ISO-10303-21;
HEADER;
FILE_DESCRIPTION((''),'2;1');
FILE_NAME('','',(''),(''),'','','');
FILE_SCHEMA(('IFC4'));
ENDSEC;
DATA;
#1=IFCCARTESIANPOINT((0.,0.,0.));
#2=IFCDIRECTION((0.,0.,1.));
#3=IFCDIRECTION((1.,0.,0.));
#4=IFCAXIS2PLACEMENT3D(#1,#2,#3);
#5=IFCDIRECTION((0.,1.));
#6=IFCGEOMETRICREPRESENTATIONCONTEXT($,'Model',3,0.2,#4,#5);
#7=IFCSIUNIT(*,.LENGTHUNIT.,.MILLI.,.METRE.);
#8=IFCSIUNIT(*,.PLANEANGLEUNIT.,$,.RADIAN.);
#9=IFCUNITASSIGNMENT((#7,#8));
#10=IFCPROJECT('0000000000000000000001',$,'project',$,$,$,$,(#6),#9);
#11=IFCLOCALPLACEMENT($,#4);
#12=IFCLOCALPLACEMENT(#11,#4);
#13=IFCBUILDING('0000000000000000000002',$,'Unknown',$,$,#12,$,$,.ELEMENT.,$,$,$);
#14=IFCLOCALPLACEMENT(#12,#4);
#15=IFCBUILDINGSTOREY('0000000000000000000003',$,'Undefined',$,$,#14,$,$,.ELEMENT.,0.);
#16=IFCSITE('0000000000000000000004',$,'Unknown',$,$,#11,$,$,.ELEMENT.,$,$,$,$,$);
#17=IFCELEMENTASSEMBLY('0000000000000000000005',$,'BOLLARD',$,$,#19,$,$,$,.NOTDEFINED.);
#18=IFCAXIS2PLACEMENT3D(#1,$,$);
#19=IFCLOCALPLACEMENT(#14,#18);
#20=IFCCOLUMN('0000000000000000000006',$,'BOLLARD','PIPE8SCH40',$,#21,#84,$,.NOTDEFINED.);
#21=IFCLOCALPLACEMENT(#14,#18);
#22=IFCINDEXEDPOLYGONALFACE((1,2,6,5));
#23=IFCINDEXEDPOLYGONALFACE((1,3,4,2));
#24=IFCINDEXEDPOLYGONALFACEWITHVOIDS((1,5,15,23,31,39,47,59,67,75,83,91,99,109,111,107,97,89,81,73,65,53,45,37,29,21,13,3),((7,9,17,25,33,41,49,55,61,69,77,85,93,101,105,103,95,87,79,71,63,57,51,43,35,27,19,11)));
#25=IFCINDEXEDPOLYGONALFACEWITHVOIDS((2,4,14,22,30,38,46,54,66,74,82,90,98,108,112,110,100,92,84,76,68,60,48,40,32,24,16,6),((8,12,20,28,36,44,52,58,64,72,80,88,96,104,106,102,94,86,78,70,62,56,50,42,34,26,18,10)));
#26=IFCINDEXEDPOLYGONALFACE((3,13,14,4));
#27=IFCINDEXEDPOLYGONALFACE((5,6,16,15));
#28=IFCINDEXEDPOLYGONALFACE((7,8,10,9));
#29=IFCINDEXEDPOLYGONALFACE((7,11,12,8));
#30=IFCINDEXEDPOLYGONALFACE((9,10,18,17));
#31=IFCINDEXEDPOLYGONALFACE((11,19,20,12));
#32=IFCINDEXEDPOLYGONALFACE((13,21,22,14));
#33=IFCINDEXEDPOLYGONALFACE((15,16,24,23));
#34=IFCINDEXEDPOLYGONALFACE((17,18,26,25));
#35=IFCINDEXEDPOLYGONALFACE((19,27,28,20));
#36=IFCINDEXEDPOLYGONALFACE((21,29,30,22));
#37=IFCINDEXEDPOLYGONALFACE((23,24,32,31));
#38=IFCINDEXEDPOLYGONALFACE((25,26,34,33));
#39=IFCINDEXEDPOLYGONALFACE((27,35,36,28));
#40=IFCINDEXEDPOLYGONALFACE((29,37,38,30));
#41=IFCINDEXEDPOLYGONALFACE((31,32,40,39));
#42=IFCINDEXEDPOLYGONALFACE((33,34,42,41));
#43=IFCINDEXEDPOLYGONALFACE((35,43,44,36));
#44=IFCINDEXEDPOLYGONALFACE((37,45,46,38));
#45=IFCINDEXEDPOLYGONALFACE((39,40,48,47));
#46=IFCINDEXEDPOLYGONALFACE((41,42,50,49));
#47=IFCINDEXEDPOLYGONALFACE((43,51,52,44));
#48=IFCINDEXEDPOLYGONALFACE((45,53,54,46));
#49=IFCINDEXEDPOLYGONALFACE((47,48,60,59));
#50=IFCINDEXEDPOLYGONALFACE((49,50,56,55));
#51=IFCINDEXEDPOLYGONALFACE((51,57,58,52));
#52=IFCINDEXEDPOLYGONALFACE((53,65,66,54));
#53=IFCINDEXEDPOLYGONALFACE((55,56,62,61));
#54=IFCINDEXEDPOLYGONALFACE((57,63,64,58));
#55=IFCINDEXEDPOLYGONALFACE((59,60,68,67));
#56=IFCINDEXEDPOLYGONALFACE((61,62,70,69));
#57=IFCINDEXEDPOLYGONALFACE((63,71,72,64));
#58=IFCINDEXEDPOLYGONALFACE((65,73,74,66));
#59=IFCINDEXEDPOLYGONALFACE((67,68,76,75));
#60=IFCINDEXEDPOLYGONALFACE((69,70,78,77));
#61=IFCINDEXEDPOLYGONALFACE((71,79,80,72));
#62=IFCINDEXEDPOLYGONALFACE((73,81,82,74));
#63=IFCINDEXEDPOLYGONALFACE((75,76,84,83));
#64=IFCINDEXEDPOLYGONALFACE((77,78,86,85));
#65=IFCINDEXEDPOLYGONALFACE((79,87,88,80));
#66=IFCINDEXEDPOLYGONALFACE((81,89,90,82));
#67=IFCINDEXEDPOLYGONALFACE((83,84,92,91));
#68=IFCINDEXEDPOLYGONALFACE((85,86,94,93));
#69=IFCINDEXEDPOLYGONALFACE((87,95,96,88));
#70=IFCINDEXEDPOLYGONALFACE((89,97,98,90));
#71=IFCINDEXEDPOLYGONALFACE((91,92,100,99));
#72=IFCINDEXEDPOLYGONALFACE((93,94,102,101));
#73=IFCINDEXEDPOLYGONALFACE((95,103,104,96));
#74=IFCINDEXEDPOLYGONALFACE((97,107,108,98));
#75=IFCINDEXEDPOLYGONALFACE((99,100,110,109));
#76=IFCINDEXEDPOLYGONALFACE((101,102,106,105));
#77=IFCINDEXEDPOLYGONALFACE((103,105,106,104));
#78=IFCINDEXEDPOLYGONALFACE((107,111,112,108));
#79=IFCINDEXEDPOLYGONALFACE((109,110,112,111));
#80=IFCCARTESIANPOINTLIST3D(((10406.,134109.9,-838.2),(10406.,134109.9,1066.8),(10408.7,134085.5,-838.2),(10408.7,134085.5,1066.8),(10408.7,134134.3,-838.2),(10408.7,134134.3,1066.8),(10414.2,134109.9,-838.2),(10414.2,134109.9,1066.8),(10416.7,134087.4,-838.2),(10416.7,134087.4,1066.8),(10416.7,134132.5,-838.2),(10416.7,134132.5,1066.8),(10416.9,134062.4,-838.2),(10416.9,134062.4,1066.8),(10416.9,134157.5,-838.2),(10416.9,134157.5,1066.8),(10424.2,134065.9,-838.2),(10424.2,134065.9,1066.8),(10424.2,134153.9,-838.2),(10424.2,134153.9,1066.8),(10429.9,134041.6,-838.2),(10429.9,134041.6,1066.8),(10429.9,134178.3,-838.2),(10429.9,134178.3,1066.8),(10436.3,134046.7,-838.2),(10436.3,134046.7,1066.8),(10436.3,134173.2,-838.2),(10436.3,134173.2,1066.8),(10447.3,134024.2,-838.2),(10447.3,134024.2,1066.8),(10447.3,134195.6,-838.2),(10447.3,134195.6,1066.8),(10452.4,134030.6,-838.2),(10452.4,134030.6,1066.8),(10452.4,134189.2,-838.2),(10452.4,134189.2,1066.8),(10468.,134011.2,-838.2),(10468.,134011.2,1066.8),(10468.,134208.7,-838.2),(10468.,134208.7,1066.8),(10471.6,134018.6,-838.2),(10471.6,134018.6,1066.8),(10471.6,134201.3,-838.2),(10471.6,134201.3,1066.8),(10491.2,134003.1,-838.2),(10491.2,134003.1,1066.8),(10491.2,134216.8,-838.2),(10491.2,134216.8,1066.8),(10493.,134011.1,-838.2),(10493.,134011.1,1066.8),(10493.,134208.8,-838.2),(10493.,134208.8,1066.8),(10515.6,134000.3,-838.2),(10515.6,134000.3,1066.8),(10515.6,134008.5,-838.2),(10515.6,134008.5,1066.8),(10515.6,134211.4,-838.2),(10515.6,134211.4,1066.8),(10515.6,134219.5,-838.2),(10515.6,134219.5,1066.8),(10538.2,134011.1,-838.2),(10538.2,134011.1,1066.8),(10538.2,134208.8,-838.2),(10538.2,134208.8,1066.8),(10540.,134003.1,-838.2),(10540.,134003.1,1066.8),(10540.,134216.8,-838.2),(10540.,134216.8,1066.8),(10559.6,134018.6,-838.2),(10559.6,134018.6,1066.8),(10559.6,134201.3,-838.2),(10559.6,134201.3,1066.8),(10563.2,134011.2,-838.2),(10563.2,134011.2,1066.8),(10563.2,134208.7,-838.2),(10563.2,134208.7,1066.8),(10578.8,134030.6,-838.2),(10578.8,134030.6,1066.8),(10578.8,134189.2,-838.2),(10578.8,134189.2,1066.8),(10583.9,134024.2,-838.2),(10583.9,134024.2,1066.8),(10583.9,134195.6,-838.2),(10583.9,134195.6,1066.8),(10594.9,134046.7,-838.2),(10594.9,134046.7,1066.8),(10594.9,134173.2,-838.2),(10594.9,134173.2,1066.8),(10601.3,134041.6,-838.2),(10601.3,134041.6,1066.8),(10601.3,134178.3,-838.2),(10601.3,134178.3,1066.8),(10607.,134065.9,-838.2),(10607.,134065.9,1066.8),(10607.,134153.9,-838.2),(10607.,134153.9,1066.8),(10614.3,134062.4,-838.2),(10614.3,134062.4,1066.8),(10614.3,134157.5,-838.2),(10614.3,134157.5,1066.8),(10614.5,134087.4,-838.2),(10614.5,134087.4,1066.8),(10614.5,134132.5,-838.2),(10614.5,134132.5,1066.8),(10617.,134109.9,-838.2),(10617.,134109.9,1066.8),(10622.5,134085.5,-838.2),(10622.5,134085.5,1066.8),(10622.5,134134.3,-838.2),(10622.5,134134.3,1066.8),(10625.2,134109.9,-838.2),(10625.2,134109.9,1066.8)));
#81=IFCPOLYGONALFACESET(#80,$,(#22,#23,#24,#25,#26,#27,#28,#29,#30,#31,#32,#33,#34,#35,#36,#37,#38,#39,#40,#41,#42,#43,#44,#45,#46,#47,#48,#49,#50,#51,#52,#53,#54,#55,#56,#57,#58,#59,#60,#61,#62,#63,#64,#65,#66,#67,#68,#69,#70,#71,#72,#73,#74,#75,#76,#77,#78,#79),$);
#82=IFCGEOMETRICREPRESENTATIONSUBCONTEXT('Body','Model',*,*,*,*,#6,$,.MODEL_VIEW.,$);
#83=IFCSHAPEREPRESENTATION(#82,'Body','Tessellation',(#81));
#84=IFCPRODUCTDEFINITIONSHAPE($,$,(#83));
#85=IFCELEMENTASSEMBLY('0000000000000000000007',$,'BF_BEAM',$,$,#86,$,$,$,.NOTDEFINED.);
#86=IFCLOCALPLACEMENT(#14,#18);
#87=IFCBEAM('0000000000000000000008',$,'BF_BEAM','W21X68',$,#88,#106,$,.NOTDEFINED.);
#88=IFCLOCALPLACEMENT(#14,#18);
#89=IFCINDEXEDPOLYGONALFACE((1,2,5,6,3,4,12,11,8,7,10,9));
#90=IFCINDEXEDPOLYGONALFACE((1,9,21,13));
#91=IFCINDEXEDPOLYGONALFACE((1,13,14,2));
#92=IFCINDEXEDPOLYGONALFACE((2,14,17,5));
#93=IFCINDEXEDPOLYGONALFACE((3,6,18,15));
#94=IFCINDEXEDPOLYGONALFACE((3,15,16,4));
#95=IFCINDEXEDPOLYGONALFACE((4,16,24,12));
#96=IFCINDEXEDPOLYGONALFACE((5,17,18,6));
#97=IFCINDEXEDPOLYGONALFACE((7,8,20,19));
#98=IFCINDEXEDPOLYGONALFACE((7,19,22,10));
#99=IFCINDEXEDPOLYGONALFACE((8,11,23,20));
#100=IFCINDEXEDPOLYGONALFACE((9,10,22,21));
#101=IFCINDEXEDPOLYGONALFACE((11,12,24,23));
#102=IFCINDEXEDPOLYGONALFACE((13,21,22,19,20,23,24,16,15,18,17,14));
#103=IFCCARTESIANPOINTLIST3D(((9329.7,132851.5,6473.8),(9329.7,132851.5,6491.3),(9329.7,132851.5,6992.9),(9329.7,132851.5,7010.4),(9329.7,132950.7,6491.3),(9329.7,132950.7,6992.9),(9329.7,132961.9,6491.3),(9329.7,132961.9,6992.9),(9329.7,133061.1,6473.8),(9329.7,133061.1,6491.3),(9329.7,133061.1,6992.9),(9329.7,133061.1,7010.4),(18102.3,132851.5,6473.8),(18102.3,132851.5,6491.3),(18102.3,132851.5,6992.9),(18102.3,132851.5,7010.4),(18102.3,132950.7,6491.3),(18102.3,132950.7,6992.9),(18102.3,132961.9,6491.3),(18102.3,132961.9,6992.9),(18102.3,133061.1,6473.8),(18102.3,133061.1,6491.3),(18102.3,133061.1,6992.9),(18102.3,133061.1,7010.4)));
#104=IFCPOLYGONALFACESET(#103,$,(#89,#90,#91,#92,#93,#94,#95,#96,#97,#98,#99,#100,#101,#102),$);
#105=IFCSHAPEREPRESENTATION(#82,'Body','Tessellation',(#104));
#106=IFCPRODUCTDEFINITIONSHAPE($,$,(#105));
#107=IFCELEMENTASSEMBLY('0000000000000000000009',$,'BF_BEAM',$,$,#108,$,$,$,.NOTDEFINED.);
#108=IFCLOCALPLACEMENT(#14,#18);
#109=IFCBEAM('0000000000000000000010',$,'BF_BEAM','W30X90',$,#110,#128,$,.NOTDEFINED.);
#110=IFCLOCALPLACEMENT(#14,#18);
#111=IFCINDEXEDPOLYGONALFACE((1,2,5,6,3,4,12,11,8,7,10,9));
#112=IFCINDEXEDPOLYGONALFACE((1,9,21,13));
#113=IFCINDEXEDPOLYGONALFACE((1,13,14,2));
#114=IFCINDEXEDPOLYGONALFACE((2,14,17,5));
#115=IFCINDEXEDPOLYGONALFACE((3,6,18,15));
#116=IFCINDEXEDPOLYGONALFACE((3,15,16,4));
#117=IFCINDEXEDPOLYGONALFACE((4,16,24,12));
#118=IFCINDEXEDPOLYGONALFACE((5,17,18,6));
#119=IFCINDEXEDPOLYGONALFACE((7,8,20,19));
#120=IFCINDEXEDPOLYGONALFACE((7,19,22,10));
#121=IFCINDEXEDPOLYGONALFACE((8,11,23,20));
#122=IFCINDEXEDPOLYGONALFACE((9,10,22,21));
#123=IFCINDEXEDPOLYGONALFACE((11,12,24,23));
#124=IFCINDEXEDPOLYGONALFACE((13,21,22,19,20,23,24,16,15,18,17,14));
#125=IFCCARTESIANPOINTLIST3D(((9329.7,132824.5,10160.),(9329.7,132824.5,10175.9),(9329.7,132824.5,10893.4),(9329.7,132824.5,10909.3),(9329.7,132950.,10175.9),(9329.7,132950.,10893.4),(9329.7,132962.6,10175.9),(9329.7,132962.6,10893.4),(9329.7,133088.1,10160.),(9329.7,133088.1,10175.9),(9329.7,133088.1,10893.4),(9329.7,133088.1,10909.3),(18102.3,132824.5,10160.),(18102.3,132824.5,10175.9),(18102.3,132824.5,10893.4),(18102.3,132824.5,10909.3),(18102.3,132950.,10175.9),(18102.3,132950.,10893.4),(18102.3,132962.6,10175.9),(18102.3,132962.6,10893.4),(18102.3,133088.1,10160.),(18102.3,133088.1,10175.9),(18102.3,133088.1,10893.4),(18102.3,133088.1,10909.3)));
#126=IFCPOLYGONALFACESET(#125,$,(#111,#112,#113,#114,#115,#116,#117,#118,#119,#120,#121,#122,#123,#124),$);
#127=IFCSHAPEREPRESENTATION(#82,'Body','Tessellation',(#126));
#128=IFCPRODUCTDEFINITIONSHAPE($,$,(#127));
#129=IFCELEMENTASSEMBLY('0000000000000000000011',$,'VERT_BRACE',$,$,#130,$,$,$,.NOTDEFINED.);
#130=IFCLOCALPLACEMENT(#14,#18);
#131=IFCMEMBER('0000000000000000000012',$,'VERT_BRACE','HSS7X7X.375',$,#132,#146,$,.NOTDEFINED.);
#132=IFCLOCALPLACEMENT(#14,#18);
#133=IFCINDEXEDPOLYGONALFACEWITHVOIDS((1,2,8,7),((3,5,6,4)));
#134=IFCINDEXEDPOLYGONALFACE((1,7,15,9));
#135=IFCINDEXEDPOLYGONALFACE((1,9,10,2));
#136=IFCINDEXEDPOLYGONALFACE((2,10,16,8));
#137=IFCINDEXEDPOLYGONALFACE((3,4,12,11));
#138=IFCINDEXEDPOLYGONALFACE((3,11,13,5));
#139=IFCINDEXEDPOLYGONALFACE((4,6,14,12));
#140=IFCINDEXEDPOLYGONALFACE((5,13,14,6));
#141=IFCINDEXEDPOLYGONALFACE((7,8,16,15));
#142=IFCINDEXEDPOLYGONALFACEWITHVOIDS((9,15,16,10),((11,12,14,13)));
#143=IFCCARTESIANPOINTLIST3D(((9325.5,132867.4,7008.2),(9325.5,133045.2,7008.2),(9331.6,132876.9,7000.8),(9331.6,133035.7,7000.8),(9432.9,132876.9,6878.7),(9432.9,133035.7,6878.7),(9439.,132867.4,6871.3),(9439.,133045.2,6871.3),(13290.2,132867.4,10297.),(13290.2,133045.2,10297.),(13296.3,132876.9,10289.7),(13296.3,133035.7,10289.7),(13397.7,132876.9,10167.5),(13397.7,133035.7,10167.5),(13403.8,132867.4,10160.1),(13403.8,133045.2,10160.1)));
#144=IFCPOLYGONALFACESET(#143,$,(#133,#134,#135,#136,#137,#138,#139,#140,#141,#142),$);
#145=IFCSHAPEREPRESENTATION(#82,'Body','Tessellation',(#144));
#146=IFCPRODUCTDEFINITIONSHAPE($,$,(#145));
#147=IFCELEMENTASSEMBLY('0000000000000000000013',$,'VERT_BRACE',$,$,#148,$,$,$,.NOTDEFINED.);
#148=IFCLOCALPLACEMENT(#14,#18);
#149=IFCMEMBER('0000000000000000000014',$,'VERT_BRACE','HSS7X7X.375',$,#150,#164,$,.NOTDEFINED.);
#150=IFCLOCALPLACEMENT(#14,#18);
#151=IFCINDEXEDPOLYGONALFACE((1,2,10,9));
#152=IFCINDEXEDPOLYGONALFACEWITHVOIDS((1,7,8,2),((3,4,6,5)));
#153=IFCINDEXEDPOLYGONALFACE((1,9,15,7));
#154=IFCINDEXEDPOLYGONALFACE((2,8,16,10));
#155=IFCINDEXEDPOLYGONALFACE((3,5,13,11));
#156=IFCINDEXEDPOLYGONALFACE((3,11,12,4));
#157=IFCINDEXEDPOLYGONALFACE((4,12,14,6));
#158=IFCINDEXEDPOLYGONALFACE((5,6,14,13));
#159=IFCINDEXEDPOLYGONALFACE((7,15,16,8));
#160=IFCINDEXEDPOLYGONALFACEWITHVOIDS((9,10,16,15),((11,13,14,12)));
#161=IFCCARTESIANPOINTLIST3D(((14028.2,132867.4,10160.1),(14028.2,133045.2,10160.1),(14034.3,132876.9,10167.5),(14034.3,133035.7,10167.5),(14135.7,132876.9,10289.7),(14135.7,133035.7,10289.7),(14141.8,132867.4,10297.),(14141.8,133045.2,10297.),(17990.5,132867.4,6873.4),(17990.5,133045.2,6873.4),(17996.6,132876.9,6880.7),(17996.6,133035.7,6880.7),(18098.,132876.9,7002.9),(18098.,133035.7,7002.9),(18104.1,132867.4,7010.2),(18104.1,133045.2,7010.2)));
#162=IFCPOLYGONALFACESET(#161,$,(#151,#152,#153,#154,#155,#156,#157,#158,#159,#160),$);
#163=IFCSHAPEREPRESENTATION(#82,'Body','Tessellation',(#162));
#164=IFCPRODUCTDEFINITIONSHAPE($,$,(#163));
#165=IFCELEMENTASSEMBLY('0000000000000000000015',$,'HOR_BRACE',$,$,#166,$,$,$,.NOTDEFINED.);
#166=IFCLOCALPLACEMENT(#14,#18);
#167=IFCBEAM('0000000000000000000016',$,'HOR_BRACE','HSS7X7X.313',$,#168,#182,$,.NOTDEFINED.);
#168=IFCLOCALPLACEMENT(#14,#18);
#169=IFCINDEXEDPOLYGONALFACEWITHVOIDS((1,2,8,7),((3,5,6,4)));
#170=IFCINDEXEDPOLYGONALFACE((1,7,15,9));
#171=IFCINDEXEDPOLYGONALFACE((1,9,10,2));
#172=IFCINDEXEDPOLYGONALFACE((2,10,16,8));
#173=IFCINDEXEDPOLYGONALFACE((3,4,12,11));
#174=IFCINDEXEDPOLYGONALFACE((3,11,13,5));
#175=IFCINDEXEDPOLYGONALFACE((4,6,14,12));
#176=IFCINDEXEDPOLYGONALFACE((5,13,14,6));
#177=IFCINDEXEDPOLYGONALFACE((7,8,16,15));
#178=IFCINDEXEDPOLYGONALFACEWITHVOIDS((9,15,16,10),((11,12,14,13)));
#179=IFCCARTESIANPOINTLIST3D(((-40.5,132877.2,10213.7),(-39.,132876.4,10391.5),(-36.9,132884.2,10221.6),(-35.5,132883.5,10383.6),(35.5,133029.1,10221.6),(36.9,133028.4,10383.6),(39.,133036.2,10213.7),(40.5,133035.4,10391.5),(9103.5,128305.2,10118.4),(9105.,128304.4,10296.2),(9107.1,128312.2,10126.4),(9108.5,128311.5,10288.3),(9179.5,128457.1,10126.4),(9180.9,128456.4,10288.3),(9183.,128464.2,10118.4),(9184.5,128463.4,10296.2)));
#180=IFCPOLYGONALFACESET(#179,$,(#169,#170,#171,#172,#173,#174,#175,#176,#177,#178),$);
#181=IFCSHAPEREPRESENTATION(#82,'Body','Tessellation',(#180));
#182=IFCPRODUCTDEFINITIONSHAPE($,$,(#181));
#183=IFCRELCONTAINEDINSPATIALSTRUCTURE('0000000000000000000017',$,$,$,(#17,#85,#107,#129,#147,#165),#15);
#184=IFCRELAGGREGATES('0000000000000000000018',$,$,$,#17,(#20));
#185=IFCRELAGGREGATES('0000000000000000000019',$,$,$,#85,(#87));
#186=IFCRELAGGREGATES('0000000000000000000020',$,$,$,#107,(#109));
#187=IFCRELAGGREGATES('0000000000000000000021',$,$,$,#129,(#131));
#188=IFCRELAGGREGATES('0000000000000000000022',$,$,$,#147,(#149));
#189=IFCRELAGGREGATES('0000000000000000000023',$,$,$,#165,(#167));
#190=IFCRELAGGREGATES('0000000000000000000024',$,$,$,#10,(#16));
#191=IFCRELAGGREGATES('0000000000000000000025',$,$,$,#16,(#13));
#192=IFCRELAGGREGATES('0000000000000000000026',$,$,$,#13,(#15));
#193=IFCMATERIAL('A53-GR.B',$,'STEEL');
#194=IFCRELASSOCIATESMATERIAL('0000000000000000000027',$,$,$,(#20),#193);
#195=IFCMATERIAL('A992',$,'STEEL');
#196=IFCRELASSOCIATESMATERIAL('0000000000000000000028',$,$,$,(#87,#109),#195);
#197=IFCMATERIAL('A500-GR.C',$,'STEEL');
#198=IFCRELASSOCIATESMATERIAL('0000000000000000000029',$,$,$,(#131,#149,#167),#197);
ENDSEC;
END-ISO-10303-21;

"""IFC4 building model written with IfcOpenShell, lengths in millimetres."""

from ifc_helpers import new_model, si_unit, direction, frame, origin_with_axes, place, context, subcontext, project, spatial, line, indexed_curve, outline, extrude, material, element, aggregate, save


model = new_model("IFC4")

# Units and contexts
model_context = context("Model", 3, precision=0.2, world=origin_with_axes(), true_north=direction((0.0, 1.0)))
body_context = subcontext(model_context, "Body", "Model", "MODEL_VIEW")
ifc_project = project(units=[si_unit("LENGTHUNIT", "METRE", prefix="MILLI"), si_unit("PLANEANGLEUNIT", "RADIAN")], contexts=[model_context])

# Site, building, storey
site_placement = place(None, origin_with_axes())
site = spatial("IfcSite", under=ifc_project, at=site_placement, Name="Unknown", CompositionType="ELEMENT")
building_placement = place(site_placement, origin_with_axes())
building = spatial("IfcBuilding", under=site, at=building_placement, Name="Unknown", CompositionType="ELEMENT")
storey_placement = place(building_placement, origin_with_axes())
storey = spatial("IfcBuildingStorey", under=building, at=storey_placement, Name="Undefined", CompositionType="ELEMENT", Elevation=0.0)

# Element assembly, column
ifc_material_1 = material(Name="A992", Category="STEEL")
ifc_material_2 = material(Name="A500-GR.C", Category="STEEL")
ifc_material_3 = material(Name="A53-GR.B", Category="STEEL")
assembly_1_placement = place(storey_placement, frame((10515.6, 134109.9, -838.2), z_axis=(-1.0, 0.0, 0.0), x_axis=(0.0, 0.0, 1.0)))
assembly_1 = element("IfcElementAssembly", 1, at=assembly_1_placement, inside=storey, Name="BOLLARD", PredefinedType="NOTDEFINED")
column_1_placement = place(assembly_1_placement, origin_with_axes())
column_1 = element("IfcColumn", 2, at=column_1_placement, material=ifc_material_3, Name="BOLLARD", Description="PIPE8SCH40", PredefinedType="NOTDEFINED", context=body_context, shape_type="SolidModel", body=[
    extrude(outline(indexed_curve([(109.6, 0.0), (106.9, 24.4), (98.7, 47.6), (85.7, 68.3), (68.3, 85.7), (47.6, 98.7), (24.4, 106.9), (0.0, 109.6), (-24.4, 106.9), (-47.6, 98.7), (-68.3, 85.7), (-85.7, 68.3), (-98.7, 47.6), (-106.9, 24.4), (-109.6, 0.0), (-106.9, -24.4), (-98.7, -47.6), (-85.7, -68.3), (-68.3, -85.7), (-47.6, -98.7), (-24.4, -106.9), (0.0, -109.6), (24.4, -106.9), (47.6, -98.7), (68.3, -85.7), (85.7, -68.3), (98.7, -47.6), (106.9, -24.4)], segments=[line(1, 2, 3, 4, 5, 6, 7, 8, 9, 10, 11, 12, 13, 14, 15, 16, 17, 18, 19, 20, 21, 22, 23, 24, 25, 26, 27, 28, 1)]), holes=[indexed_curve([(101.4, 0.0), (98.9, -22.6), (91.4, -44.0), (79.3, -63.2), (63.2, -79.3), (44.0, -91.4), (22.6, -98.9), (0.0, -101.4), (-22.6, -98.9), (-44.0, -91.4), (-63.2, -79.3), (-79.3, -63.2), (-91.4, -44.0), (-98.9, -22.6), (-101.4, 0.0), (-98.9, 22.6), (-91.4, 44.0), (-79.3, 63.2), (-63.2, 79.3), (-44.0, 91.4), (-22.6, 98.9), (0.0, 101.4), (22.6, 98.9), (44.0, 91.4), (63.2, 79.3), (79.3, 63.2), (91.4, 44.0), (98.9, 22.6)], segments=[line(1, 2, 3, 4, 5, 6, 7, 8, 9, 10, 11, 12, 13, 14, 15, 16, 17, 18, 19, 20, 21, 22, 23, 24, 25, 26, 27, 28, 1)])]), frame((0.0, 0.0, 0.0), z_axis=(-1.0, 0.0, 0.0), x_axis=(0.0, 0.0, 1.0)), (0.0, 0.0, -1.0), 1905.0),
])
aggregate(assembly_1, [column_1])

# Element assemblies, beams
assembly_2_placement = place(storey_placement, frame((9329.7, 132956.3, 6742.1), z_axis=(0.0, -1.0, 0.0), x_axis=(1.0, 0.0, 0.0)))
assembly_2 = element("IfcElementAssembly", 3, at=assembly_2_placement, inside=storey, Name="BF_BEAM", PredefinedType="NOTDEFINED")
beam_1_placement = place(assembly_2_placement, origin_with_axes())
beam_1 = element("IfcBeam", 4, at=beam_1_placement, material=ifc_material_1, Name="BF_BEAM", Description="W21X68", PredefinedType="NOTDEFINED", context=body_context, shape_type="SolidModel", body=[
    extrude(outline(indexed_curve([(-104.8, -268.3), (104.8, -268.3), (104.8, -250.8), (5.6, -250.8), (5.6, 250.8), (104.8, 250.8), (104.8, 268.3), (-104.8, 268.3), (-104.8, 250.8), (-5.6, 250.8), (-5.6, -250.8), (-104.8, -250.8)], segments=[line(1, 2, 3, 4, 5, 6, 7, 8, 9, 10, 11, 12, 1)])), frame((0.0, 0.0, 0.0), z_axis=(-1.0, 0.0, 0.0), x_axis=(0.0, 0.0, 1.0)), (0.0, 0.0, -1.0), 8772.5),
])
aggregate(assembly_2, [beam_1])
assembly_3_placement = place(storey_placement, frame((9329.7, 132956.3, 10534.6), z_axis=(0.0, -1.0, 0.0), x_axis=(1.0, 0.0, 0.0)))
assembly_3 = element("IfcElementAssembly", 5, at=assembly_3_placement, inside=storey, Name="BF_BEAM", PredefinedType="NOTDEFINED")
beam_2_placement = place(assembly_3_placement, origin_with_axes())
beam_2 = element("IfcBeam", 6, at=beam_2_placement, material=ifc_material_1, Name="BF_BEAM", Description="W30X90", PredefinedType="NOTDEFINED", context=body_context, shape_type="SolidModel", body=[
    extrude(outline(indexed_curve([(-131.8, -374.6), (131.8, -374.6), (131.8, -358.8), (6.3, -358.8), (6.3, 358.8), (131.8, 358.8), (131.8, 374.6), (-131.8, 374.6), (-131.8, 358.8), (-6.3, 358.8), (-6.3, -358.8), (-131.8, -358.8)], segments=[line(1, 2, 3, 4, 5, 6, 7, 8, 9, 10, 11, 12, 1)])), frame((0.0, 0.0, 0.0), z_axis=(-1.0, 0.0, 0.0), x_axis=(0.0, 0.0, 1.0)), (0.0, 0.0, -1.0), 8772.5),
])
aggregate(assembly_3, [beam_2])

# Element assemblies, members
assembly_4_placement = place(storey_placement, frame((9382.3, 132956.3, 6939.8), z_axis=(0.0, -1.0, 0.0), x_axis=(0.769665, 0.0, 0.638448)))
assembly_4 = element("IfcElementAssembly", 7, at=assembly_4_placement, inside=storey, Name="VERT_BRACE", PredefinedType="NOTDEFINED")
member_1_placement = place(assembly_4_placement, origin_with_axes())
member_1 = element("IfcMember", 8, at=member_1_placement, material=ifc_material_2, Name="VERT_BRACE", Description="HSS7X7X.375", PredefinedType="NOTDEFINED", context=body_context, shape_type="SolidModel", body=[
    extrude(outline(indexed_curve([(-88.9, -88.9), (88.9, -88.9), (88.9, 88.9), (-88.9, 88.9)], segments=[line(1, 2, 3, 4, 1)]), holes=[indexed_curve([(-79.4, -79.4), (-79.4, 79.4), (79.4, 79.4), (79.4, -79.4)], segments=[line(1, 2, 3, 4, 1)])]), frame((0.0, 0.0, 0.0), z_axis=(-1.0, 0.0, 0.0), x_axis=(0.0, 0.0, 1.0)), (0.0, 0.0, -1.0), 5151.3),
])
aggregate(assembly_4, [member_1])
assembly_5_placement = place(storey_placement, frame((18047.3, 132956.3, 6941.8), z_axis=(0.0, 1.0, 0.0), x_axis=(-0.769665, 0.0, 0.638448)))
assembly_5 = element("IfcElementAssembly", 9, at=assembly_5_placement, inside=storey, Name="VERT_BRACE", PredefinedType="NOTDEFINED")
member_2_placement = place(assembly_5_placement, origin_with_axes())
member_2 = element("IfcMember", 10, at=member_2_placement, material=ifc_material_2, Name="VERT_BRACE", Description="HSS7X7X.375", PredefinedType="NOTDEFINED", context=body_context, shape_type="SolidModel", body=[
    extrude(outline(indexed_curve([(-88.9, -88.9), (88.9, -88.9), (88.9, 88.9), (-88.9, 88.9)], segments=[line(1, 2, 3, 4, 1)]), holes=[indexed_curve([(-79.4, -79.4), (-79.4, 79.4), (79.4, 79.4), (79.4, -79.4)], segments=[line(1, 2, 3, 4, 1)])]), frame((0.0, 0.0, 0.0), z_axis=(-1.0, 0.0, 0.0), x_axis=(0.0, 0.0, 1.0)), (0.0, 0.0, -1.0), 5148.1),
])
aggregate(assembly_5, [member_2])

# Element assembly, beam
assembly_6_placement = place(storey_placement, frame((9144.0, 128384.3, 10207.3), z_axis=(0.447214, 0.894427, 0.0), x_axis=(-0.894388, 0.447194, 0.009317)))
assembly_6 = element("IfcElementAssembly", 11, at=assembly_6_placement, inside=storey, Name="HOR_BRACE", PredefinedType="NOTDEFINED")
beam_3_placement = place(assembly_6_placement, origin_with_axes())
beam_3 = element("IfcBeam", 12, at=beam_3_placement, material=ifc_material_2, Name="HOR_BRACE", Description="HSS7X7X.313", PredefinedType="NOTDEFINED", context=body_context, shape_type="SolidModel", body=[
    extrude(outline(indexed_curve([(-88.9, -88.9), (88.9, -88.9), (88.9, 88.9), (-88.9, 88.9)], segments=[line(1, 2, 3, 4, 1)]), holes=[indexed_curve([(-81.0, -81.0), (-81.0, 81.0), (81.0, 81.0), (81.0, -81.0)], segments=[line(1, 2, 3, 4, 1)])]), frame((0.0, 0.0, 0.0), z_axis=(-1.0, 0.0, 0.0), x_axis=(0.0, 0.0, 1.0)), (0.0, 0.0, -1.0), 10223.7),
])
aggregate(assembly_6, [beam_3])

save(model, "model.ifc")
